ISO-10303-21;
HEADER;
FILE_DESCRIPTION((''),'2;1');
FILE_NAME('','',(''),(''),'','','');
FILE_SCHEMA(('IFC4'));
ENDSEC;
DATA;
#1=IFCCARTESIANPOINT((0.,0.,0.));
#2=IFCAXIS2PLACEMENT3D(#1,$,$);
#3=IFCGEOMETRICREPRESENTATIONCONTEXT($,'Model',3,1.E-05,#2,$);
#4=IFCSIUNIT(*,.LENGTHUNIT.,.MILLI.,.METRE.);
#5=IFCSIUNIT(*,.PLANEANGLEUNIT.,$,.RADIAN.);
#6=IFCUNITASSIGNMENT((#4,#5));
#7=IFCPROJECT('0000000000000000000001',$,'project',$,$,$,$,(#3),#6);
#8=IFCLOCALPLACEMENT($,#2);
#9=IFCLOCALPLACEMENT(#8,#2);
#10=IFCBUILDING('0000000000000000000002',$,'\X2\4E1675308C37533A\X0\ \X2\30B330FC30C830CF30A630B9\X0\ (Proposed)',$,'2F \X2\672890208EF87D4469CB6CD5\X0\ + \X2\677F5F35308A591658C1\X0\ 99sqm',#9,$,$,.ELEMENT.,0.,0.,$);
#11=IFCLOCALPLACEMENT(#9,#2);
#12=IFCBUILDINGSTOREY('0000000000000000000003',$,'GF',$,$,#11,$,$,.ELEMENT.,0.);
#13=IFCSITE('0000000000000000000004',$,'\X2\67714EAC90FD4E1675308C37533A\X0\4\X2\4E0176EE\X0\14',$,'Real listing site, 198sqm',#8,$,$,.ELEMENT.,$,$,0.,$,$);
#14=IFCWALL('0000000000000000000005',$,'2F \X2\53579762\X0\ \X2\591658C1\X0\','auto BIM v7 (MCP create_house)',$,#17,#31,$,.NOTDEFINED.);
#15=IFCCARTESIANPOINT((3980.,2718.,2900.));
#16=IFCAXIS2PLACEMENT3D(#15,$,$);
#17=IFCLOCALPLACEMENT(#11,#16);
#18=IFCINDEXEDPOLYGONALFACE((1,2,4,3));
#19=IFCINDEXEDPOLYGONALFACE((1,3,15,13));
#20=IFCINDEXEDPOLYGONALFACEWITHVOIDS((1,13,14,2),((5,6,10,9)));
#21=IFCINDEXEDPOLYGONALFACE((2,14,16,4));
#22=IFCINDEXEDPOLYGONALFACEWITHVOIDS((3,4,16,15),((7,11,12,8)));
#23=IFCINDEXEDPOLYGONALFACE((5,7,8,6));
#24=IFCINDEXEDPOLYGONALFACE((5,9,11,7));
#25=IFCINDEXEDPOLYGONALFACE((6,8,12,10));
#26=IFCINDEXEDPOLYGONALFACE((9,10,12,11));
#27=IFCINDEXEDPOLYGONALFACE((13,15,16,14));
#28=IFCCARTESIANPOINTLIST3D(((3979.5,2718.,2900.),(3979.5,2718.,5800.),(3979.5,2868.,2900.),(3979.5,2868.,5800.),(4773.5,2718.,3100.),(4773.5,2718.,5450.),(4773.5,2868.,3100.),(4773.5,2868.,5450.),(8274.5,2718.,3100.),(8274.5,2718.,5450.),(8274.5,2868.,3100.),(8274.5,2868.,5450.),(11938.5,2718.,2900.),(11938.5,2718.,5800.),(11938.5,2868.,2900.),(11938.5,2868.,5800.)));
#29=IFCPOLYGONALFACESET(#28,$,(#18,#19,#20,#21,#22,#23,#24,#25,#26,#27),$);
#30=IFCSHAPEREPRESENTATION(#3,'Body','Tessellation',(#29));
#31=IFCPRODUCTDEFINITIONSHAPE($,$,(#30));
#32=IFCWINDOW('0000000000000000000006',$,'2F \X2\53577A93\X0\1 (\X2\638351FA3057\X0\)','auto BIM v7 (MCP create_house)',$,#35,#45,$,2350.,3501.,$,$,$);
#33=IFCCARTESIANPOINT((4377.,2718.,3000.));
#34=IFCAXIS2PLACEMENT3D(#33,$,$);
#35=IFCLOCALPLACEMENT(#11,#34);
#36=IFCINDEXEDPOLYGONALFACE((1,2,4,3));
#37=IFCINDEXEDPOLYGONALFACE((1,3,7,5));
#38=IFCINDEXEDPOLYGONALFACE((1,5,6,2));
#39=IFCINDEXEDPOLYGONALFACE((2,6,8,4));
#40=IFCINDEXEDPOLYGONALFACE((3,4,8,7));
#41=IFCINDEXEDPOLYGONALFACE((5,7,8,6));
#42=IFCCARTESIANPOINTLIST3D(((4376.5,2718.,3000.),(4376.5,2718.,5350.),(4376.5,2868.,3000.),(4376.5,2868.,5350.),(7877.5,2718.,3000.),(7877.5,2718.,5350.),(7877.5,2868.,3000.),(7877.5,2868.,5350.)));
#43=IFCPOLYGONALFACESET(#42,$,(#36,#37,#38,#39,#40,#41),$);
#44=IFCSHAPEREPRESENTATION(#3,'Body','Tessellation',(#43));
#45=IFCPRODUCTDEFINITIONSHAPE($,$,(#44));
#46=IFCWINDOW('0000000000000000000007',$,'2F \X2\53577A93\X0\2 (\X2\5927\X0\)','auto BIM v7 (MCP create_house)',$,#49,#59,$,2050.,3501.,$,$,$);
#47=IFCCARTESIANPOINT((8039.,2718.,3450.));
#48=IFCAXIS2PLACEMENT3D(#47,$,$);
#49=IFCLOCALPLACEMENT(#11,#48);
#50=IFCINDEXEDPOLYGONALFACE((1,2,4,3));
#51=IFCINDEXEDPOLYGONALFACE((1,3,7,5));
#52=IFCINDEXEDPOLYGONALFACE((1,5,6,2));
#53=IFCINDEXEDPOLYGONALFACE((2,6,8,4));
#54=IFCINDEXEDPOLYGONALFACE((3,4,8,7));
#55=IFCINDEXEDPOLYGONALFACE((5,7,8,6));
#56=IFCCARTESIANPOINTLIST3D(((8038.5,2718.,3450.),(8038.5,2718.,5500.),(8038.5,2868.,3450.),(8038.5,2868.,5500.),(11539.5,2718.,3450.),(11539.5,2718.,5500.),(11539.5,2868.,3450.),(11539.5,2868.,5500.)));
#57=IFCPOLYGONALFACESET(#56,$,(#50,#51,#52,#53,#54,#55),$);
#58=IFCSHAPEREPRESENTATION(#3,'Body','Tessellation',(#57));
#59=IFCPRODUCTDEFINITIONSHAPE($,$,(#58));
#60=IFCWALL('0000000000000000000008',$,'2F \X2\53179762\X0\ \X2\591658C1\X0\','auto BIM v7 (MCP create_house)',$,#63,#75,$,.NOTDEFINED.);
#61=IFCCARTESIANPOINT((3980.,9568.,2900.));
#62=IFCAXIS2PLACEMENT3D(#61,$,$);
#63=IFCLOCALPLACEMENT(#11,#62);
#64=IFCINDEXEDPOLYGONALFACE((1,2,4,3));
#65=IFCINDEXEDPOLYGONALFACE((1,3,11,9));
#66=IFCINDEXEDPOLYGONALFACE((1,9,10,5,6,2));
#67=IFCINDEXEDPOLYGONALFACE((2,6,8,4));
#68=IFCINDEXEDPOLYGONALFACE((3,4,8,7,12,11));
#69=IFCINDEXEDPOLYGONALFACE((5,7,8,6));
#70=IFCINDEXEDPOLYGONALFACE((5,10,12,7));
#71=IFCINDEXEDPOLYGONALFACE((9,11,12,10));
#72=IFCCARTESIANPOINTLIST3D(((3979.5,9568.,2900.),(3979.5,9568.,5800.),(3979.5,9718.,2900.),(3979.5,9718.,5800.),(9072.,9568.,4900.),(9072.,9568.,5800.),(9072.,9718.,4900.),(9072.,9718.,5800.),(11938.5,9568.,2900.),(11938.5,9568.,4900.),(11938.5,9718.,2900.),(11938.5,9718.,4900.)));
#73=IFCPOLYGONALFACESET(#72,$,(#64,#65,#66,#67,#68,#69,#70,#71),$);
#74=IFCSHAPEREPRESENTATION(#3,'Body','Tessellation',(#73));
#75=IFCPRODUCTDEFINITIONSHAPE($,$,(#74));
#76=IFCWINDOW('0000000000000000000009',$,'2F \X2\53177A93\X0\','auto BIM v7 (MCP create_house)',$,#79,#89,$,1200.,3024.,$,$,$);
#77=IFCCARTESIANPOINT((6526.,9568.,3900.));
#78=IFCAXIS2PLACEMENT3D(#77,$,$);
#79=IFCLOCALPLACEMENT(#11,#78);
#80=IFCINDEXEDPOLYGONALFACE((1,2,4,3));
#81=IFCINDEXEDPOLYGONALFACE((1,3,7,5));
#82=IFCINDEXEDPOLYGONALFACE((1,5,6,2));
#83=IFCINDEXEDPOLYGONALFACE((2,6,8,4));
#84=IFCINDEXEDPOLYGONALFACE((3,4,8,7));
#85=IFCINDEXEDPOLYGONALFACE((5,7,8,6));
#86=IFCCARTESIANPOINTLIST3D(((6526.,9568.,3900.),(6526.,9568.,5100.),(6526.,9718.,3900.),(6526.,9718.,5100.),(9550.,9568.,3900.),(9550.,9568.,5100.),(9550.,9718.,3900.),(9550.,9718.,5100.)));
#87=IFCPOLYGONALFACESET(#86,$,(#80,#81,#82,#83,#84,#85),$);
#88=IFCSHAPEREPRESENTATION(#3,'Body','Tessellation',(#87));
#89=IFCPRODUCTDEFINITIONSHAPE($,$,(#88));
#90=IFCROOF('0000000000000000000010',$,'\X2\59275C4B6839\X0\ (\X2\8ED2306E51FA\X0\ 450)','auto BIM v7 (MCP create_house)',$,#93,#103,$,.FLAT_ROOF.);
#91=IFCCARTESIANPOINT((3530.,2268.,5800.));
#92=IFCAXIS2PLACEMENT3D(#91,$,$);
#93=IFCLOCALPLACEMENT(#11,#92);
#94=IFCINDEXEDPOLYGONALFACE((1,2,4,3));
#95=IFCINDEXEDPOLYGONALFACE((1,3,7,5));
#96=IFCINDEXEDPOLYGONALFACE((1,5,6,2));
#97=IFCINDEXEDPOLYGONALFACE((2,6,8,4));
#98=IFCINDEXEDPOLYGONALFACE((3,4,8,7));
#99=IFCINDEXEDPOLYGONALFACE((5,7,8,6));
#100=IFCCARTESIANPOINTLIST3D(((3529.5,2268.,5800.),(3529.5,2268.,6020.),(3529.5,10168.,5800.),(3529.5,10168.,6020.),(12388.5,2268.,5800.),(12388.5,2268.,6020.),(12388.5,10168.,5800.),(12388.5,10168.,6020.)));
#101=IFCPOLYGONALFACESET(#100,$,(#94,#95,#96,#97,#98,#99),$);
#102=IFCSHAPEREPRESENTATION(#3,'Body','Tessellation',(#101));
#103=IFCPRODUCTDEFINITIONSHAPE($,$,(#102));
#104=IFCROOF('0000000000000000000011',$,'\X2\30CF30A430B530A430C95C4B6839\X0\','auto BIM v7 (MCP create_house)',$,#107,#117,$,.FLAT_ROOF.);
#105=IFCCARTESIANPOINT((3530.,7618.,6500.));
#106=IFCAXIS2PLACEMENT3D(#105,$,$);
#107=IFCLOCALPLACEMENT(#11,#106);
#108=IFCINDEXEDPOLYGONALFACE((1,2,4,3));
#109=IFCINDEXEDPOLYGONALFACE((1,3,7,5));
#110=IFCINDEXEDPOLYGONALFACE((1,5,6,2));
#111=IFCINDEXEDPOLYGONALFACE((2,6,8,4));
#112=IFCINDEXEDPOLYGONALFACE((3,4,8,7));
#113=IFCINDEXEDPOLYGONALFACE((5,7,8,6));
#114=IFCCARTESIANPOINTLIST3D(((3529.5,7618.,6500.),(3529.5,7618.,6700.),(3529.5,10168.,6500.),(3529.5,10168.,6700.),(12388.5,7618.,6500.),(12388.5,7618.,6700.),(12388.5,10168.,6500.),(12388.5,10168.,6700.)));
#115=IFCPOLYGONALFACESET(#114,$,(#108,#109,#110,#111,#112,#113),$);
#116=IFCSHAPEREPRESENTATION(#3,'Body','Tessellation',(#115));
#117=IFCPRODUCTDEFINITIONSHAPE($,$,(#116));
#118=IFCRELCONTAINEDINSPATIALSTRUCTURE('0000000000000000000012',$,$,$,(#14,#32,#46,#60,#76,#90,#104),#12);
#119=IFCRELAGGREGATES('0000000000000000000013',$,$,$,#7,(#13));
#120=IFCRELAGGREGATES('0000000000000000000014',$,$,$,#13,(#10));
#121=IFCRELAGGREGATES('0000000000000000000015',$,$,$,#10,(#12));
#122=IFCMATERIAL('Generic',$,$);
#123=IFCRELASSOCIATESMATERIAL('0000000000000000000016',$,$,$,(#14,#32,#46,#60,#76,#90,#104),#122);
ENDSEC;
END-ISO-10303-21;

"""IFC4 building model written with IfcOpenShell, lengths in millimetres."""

from ifc_helpers import new_model, si_unit, frame, frame_2d, origin, place, context, project, spatial, rectangle, extrude, material, element, fill, save


model = new_model("IFC4")

# Units and contexts
model_context = context("Model", 3, precision=1e-05, world=origin())
ifc_project = project(units=[si_unit("LENGTHUNIT", "METRE", prefix="MILLI"), si_unit("PLANEANGLEUNIT", "RADIAN")], contexts=[model_context])

# Site, building, storey
site_placement = place(None, origin())
site = spatial("IfcSite", under=ifc_project, at=site_placement, Name="東京都世田谷区4丁目14", ObjectType="Real listing site, 198sqm", CompositionType="ELEMENT", RefElevation=0.0)
building_placement = place(site_placement, origin())
building = spatial("IfcBuilding", under=site, at=building_placement, Name="世田谷区 コートハウス (Proposed)", ObjectType="2F 木造軸組構法 + 板張り外壁 99sqm", CompositionType="ELEMENT", ElevationOfRefHeight=0.0, ElevationOfTerrain=0.0)
storey_placement = place(building_placement, origin())
storey = spatial("IfcBuildingStorey", under=building, at=storey_placement, Name="GF", CompositionType="ELEMENT", Elevation=0.0)

# Shared definitions
ifc_material = material(Name="Generic")

# Wall, openings, windows
wall_1_placement = place(storey_placement, frame((3980.0, 2718.0, 2900.0)))
wall_1 = element("IfcWall", 1, at=wall_1_placement, inside=storey, material=ifc_material, Name="2F 南面 外壁", Description="auto BIM v7 (MCP create_house)", PredefinedType="NOTDEFINED", context=model_context, shape_type="SweptSolid", body=[
    extrude(rectangle(XDim=7959.0, YDim=150.0, at=frame_2d((3979.0, 75.0))), frame((3980.0, 2718.0, 2900.0)), (0.0, 0.0, 1.0), 2900.0),
])
opening_1_placement = place(storey_placement, frame((4377.0, 2718.0, 3000.0)))
opening_1 = element("IfcOpeningElement", 2, at=opening_1_placement, cuts=wall_1, PredefinedType="NOTDEFINED", context=model_context, shape_type="SweptSolid", body=[
    extrude(rectangle(XDim=3501.0, YDim=150.0, at=frame_2d((1750.0, 75.0))), frame((4377.0, 2718.0, 3000.0)), (0.0, 0.0, 1.0), 2350.0),
])
opening_2_placement = place(storey_placement, frame((8039.0, 2718.0, 3450.0)))
opening_2 = element("IfcOpeningElement", 3, at=opening_2_placement, cuts=wall_1, PredefinedType="NOTDEFINED", context=model_context, shape_type="SweptSolid", body=[
    extrude(rectangle(XDim=3501.0, YDim=150.0, at=frame_2d((1750.0, 75.0))), frame((8039.0, 2718.0, 3450.0)), (0.0, 0.0, 1.0), 2050.0),
])
window_1_placement = place(storey_placement, frame((4377.0, 2718.0, 3000.0)))
window_1 = element("IfcWindow", 4, at=window_1_placement, inside=storey, material=ifc_material, Name="2F 南窓1 (掃出し)", Description="auto BIM v7 (MCP create_house)", OverallHeight=2350.0, OverallWidth=3501.0, context=model_context, shape_type="SweptSolid", body=[
    extrude(rectangle(XDim=3501.0, YDim=150.0, at=frame_2d((1750.0, 75.0))), frame((4377.0, 2718.0, 3000.0)), (0.0, 0.0, 1.0), 2350.0),
])
fill(opening_1, window_1)
window_2_placement = place(storey_placement, frame((8039.0, 2718.0, 3450.0)))
window_2 = element("IfcWindow", 5, at=window_2_placement, inside=storey, material=ifc_material, Name="2F 南窓2 (大)", Description="auto BIM v7 (MCP create_house)", OverallHeight=2050.0, OverallWidth=3501.0, context=model_context, shape_type="SweptSolid", body=[
    extrude(rectangle(XDim=3501.0, YDim=150.0, at=frame_2d((1750.0, 75.0))), frame((8039.0, 2718.0, 3450.0)), (0.0, 0.0, 1.0), 2050.0),
])
fill(opening_2, window_2)

# Wall, opening, window
wall_2_placement = place(storey_placement, frame((3980.0, 9568.0, 2900.0)))
wall_2 = element("IfcWall", 6, at=wall_2_placement, inside=storey, material=ifc_material, Name="2F 北面 外壁", Description="auto BIM v7 (MCP create_house)", PredefinedType="NOTDEFINED", context=model_context, shape_type="SweptSolid", body=[
    extrude(rectangle(XDim=7959.0, YDim=150.0, at=frame_2d((3979.0, 75.0))), frame((3980.0, 9568.0, 2900.0)), (0.0, 0.0, 1.0), 2900.0),
])
opening_3_placement = place(storey_placement, frame((6526.0, 9568.0, 3900.0)))
opening_3 = element("IfcOpeningElement", 7, at=opening_3_placement, cuts=wall_2, PredefinedType="NOTDEFINED", context=model_context, shape_type="SweptSolid", body=[
    extrude(rectangle(XDim=3024.0, YDim=150.0, at=frame_2d((1512.0, 75.0))), frame((6526.0, 9568.0, 3900.0)), (0.0, 0.0, 1.0), 1200.0),
])
window_3_placement = place(storey_placement, frame((6526.0, 9568.0, 3900.0)))
window_3 = element("IfcWindow", 8, at=window_3_placement, inside=storey, material=ifc_material, Name="2F 北窓", Description="auto BIM v7 (MCP create_house)", OverallHeight=1200.0, OverallWidth=3024.0, context=model_context, shape_type="SweptSolid", body=[
    extrude(rectangle(XDim=3024.0, YDim=150.0, at=frame_2d((1512.0, 75.0))), frame((6526.0, 9568.0, 3900.0)), (0.0, 0.0, 1.0), 1200.0),
])
fill(opening_3, window_3)

# Roofs
roof_1_placement = place(storey_placement, frame((3530.0, 2268.0, 5800.0)))
element("IfcRoof", 9, at=roof_1_placement, inside=storey, material=ifc_material, Name="大屋根 (軒の出 450)", Description="auto BIM v7 (MCP create_house)", PredefinedType="FLAT_ROOF", context=model_context, shape_type="SweptSolid", body=[
    extrude(rectangle(XDim=8859.0, YDim=7900.0, at=frame_2d((4429.0, 3950.0))), frame((3530.0, 2268.0, 5800.0)), (0.0, 0.0, 1.0), 220.0),
])
roof_2_placement = place(storey_placement, frame((3530.0, 7618.0, 6500.0)))
element("IfcRoof", 10, at=roof_2_placement, inside=storey, material=ifc_material, Name="ハイサイド屋根", Description="auto BIM v7 (MCP create_house)", PredefinedType="FLAT_ROOF", context=model_context, shape_type="SweptSolid", body=[
    extrude(rectangle(XDim=8859.0, YDim=2550.0, at=frame_2d((4429.0, 1275.0))), frame((3530.0, 7618.0, 6500.0)), (0.0, 0.0, 1.0), 200.0),
])

save(model, "model.ifc")
